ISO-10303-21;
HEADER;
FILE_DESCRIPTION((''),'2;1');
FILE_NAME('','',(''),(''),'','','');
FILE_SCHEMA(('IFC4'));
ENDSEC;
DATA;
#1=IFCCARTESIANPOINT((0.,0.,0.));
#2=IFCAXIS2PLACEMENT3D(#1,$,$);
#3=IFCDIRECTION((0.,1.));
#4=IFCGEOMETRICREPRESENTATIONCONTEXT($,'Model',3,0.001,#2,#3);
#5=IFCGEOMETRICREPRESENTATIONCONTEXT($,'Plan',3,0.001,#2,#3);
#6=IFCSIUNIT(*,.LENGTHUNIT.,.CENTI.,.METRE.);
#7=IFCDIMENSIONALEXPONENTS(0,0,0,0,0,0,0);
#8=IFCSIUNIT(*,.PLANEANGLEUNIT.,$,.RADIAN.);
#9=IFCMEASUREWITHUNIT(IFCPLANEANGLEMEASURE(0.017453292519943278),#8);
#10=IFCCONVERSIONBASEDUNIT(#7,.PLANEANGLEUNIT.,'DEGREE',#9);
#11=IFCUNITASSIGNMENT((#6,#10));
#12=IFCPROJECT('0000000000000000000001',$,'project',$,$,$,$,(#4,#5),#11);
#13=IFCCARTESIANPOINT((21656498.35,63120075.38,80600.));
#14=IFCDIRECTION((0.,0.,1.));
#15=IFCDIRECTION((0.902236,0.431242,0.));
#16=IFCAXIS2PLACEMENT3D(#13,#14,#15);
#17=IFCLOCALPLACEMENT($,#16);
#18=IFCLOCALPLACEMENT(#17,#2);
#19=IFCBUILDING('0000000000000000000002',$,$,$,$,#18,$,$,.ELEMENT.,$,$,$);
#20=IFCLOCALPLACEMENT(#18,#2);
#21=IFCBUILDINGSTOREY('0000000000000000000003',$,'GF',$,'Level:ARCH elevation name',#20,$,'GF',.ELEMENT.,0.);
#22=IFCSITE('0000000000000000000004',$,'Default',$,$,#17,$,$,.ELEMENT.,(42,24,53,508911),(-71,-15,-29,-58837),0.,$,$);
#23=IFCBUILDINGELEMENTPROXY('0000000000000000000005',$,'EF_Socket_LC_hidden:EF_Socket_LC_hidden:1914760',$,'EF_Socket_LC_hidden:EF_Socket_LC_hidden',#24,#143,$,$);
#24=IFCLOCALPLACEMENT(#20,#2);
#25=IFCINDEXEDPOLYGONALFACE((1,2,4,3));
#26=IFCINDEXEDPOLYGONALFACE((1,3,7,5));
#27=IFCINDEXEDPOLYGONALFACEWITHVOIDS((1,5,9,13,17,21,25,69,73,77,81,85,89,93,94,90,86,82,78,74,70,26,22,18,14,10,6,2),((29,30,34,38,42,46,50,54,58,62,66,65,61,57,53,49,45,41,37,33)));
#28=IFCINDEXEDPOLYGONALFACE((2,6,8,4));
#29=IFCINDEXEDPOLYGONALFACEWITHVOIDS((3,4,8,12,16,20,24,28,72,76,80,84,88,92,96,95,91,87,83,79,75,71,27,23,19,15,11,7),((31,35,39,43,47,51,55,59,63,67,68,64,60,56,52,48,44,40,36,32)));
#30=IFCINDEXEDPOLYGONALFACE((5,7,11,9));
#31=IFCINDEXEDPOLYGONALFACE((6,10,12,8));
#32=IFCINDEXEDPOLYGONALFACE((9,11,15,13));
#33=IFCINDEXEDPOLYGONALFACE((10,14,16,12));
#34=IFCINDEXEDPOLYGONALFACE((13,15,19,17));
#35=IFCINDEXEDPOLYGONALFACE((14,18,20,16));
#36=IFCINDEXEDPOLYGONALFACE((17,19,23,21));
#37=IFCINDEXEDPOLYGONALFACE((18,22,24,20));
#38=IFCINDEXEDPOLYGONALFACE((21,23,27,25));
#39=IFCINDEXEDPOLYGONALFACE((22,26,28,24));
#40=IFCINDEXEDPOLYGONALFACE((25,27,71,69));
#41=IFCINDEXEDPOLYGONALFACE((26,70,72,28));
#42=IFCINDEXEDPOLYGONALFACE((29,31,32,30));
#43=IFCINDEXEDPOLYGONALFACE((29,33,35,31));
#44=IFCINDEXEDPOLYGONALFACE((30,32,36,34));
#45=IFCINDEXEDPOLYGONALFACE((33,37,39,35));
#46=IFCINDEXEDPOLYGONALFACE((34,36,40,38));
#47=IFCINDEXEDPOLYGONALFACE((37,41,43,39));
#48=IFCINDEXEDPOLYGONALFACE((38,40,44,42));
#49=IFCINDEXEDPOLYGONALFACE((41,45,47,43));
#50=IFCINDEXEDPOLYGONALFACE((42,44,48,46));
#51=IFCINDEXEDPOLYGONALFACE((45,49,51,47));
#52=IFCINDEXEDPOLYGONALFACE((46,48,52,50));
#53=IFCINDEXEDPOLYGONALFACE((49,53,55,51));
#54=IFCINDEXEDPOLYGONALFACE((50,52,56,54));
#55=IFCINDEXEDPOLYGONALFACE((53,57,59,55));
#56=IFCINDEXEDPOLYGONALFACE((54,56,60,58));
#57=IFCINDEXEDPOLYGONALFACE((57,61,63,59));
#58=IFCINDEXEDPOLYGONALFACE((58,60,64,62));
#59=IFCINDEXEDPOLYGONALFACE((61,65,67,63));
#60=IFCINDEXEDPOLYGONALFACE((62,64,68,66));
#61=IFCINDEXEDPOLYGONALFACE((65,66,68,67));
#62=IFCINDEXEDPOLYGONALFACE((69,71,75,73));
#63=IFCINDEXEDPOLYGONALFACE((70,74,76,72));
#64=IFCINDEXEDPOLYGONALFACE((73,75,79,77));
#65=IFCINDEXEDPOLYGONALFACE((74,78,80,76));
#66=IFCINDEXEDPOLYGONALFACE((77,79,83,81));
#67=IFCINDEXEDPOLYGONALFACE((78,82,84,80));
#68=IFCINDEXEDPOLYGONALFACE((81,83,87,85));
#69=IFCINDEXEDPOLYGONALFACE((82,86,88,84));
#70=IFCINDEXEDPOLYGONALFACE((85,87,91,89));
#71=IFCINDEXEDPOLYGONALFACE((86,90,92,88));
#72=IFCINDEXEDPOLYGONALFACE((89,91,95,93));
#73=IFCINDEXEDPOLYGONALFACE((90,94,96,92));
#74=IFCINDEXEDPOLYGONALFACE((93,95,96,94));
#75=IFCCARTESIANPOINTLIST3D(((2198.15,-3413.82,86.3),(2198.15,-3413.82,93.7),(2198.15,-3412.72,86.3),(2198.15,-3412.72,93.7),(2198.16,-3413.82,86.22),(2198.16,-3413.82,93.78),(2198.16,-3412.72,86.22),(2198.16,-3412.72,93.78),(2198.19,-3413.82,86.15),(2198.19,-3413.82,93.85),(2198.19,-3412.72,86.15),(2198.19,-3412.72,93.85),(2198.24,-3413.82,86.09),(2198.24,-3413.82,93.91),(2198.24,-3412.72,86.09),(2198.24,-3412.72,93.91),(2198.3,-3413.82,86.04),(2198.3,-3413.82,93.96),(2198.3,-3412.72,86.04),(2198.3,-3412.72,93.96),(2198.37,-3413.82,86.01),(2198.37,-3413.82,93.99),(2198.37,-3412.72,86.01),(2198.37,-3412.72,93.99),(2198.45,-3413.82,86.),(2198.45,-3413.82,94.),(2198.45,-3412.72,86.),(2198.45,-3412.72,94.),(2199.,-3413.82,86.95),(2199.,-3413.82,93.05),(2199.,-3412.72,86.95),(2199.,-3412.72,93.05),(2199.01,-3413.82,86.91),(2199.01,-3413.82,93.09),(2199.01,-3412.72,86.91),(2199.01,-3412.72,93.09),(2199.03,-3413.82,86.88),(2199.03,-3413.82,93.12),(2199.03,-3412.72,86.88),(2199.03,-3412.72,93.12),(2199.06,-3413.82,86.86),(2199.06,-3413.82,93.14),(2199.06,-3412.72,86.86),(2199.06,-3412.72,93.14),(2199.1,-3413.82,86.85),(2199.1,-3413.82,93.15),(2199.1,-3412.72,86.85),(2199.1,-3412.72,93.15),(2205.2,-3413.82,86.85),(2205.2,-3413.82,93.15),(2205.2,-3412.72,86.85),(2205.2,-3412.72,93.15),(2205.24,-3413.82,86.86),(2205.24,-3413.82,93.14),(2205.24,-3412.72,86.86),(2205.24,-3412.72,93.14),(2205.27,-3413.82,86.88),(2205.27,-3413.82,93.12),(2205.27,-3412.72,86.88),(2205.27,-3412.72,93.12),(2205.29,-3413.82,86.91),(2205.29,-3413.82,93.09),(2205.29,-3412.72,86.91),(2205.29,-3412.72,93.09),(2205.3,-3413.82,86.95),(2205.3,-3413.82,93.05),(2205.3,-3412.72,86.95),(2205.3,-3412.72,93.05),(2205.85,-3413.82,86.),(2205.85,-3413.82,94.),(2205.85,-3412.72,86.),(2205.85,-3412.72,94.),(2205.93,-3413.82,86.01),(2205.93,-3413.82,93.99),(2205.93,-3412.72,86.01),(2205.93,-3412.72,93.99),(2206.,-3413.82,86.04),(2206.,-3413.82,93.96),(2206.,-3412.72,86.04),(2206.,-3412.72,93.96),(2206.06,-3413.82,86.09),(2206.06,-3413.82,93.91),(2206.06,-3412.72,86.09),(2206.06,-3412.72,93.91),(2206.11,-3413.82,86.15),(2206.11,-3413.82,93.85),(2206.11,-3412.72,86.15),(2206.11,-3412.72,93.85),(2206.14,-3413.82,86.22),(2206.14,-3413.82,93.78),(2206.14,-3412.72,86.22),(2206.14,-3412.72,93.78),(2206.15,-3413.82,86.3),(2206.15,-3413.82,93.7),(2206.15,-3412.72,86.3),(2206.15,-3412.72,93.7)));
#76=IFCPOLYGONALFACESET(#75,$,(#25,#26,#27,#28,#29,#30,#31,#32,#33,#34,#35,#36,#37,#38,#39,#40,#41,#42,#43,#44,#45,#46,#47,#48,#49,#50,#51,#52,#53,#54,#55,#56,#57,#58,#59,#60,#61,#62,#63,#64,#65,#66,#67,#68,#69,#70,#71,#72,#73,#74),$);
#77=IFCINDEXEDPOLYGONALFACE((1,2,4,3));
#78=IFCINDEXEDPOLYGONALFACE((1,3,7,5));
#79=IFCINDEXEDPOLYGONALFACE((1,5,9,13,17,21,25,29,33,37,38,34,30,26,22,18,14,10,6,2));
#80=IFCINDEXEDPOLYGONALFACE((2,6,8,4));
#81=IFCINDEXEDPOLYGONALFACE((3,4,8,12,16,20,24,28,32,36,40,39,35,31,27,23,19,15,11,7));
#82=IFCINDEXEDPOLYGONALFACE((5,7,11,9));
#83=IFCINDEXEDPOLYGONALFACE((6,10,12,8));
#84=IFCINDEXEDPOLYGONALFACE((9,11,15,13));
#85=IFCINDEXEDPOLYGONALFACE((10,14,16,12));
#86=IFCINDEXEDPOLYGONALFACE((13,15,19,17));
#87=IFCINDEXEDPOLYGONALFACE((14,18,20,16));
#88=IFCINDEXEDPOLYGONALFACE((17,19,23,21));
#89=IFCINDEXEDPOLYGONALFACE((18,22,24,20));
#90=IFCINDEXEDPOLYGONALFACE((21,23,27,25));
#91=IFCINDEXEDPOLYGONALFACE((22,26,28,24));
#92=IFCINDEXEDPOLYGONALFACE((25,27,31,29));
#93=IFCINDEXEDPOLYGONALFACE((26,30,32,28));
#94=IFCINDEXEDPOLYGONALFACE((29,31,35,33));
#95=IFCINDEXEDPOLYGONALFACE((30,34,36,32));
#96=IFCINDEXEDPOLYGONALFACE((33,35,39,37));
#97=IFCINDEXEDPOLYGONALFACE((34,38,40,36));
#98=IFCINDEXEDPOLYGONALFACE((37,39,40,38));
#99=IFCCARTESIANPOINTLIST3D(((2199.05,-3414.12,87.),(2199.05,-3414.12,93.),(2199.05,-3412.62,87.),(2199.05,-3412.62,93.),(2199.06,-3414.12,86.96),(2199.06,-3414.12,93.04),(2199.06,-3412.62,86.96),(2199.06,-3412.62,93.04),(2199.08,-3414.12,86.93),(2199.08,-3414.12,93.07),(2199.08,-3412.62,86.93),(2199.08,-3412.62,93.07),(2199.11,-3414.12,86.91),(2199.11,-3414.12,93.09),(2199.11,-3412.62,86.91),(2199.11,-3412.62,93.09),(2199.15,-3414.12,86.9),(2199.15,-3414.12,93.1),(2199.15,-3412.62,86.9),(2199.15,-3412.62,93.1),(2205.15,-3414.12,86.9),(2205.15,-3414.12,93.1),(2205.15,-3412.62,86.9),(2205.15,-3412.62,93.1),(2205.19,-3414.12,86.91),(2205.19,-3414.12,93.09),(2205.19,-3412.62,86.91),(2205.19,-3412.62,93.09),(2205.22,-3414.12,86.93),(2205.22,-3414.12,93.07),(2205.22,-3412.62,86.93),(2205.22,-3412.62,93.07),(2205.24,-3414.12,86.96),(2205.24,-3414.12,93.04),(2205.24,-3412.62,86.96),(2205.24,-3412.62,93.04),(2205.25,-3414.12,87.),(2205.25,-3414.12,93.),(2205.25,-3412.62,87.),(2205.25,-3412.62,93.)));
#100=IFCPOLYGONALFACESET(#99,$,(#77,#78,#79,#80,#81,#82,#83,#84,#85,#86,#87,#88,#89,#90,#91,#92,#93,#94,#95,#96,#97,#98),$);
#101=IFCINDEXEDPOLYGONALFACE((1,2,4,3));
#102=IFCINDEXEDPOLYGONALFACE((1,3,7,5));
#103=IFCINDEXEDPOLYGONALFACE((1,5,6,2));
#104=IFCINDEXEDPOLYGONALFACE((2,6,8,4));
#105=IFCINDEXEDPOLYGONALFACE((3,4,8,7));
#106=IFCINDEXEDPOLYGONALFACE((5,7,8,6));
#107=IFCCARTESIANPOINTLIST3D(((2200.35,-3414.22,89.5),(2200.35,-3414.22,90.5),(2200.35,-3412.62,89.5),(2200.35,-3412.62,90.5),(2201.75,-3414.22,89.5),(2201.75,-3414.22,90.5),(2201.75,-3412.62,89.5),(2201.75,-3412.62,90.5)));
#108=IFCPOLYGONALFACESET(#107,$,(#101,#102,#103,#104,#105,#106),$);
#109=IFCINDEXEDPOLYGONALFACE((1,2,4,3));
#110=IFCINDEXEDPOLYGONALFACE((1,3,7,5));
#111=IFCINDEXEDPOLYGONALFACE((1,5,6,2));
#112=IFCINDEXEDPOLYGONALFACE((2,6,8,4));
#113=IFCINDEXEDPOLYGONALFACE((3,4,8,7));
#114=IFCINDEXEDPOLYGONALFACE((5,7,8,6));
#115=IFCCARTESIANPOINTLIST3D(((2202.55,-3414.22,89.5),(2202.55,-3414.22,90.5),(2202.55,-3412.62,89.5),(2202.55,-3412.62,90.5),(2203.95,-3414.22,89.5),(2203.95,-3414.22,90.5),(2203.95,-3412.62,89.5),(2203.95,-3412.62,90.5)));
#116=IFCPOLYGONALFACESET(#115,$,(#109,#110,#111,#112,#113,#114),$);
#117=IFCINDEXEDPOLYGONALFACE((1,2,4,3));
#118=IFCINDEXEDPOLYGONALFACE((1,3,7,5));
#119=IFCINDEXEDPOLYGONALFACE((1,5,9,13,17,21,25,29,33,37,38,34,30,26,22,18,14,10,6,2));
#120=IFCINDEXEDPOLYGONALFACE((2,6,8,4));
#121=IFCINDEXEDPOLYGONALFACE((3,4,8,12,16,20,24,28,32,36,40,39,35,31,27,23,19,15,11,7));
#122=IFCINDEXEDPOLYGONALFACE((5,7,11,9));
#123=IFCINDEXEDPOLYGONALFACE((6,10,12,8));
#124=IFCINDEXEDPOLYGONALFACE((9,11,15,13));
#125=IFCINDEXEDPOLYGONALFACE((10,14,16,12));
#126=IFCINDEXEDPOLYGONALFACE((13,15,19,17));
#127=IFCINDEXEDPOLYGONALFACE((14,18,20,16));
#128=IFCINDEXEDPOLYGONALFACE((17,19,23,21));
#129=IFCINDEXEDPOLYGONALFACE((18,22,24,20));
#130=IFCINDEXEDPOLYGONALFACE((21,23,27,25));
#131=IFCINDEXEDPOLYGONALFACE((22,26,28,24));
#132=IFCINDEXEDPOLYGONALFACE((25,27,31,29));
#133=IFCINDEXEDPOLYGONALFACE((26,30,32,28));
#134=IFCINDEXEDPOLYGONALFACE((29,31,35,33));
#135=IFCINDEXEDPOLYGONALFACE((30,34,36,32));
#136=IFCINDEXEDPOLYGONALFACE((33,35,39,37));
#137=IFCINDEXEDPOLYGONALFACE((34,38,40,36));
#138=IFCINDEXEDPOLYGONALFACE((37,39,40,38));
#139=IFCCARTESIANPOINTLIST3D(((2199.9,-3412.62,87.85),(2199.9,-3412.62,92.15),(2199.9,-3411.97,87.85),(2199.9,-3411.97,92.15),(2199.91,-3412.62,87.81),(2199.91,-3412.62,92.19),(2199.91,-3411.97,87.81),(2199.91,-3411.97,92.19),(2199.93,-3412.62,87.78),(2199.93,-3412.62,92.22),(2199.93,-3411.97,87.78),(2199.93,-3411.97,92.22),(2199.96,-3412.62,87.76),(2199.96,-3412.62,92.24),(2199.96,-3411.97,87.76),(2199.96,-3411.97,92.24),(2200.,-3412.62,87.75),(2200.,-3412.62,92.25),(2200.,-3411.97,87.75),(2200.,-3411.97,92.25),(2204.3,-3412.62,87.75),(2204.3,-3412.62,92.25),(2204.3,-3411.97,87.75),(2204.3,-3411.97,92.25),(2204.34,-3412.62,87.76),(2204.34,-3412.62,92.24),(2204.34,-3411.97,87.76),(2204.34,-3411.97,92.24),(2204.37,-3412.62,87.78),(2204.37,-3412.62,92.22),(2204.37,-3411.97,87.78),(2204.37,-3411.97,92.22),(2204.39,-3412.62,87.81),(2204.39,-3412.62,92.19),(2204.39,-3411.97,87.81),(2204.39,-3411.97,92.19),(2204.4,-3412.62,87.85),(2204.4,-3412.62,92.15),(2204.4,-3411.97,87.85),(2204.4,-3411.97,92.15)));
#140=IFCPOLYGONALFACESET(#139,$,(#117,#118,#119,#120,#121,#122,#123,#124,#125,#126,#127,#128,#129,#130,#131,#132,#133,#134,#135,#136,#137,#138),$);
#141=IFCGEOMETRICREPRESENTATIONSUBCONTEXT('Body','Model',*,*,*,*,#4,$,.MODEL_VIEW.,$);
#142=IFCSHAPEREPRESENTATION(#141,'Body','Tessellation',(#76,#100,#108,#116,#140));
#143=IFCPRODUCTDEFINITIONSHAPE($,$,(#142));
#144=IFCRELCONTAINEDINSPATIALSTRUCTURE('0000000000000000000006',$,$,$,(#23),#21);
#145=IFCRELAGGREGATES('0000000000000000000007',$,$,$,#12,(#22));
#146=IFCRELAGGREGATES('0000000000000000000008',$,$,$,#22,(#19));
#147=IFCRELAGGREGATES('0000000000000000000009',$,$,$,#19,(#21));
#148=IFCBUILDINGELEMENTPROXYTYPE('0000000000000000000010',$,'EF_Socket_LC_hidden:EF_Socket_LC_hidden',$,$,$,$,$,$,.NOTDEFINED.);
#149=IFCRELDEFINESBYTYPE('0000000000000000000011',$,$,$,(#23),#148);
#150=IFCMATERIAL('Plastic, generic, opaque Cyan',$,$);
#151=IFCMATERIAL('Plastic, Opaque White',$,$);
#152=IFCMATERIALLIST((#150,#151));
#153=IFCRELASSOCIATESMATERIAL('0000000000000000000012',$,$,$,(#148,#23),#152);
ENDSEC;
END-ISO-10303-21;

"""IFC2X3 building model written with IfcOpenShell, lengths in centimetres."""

from ifc_helpers import new_model, entity, si_unit, converted_unit, direction, frame, frame_2d, origin, place, context, subcontext, project, spatial, polyline, circle_curve, parameter, trimmed, segment, composite_curve, rectangle, outline, extrude, source, transform, mapped, material, material_list, type_object, type_shapes, element, save


model = new_model("IFC2X3")

# Units and contexts
model_context = context("Model", 3, precision=0.001, world=origin(), true_north=direction((0.0, 1.0)))
plan_context = context("Plan", 3, precision=0.001, world=origin(), true_north=direction((0.0, 1.0)))
body_context = subcontext(model_context, "Body", "Model", "MODEL_VIEW")
ifc_project = project(units=[si_unit("LENGTHUNIT", "METRE", prefix="CENTI"), converted_unit("PLANEANGLEUNIT", "DEGREE", entity("IfcPlaneAngleMeasure", 0.017453292519943278), si_unit("PLANEANGLEUNIT", "RADIAN"), dimensions=[0, 0, 0, 0, 0, 0, 0])], contexts=[model_context, plan_context])

# Site, building, storey
site_placement = place(None, frame((21656498.35, 63120075.38, 80600.0), z_axis=(0.0, 0.0, 1.0), x_axis=(0.902236, 0.431242, 0.0)))
site = spatial("IfcSite", under=ifc_project, at=site_placement, Name="Default", CompositionType="ELEMENT", RefLatitude=(42, 24, 53, 508911), RefLongitude=(-71, -15, -29, -58837), RefElevation=0.0)
building_placement = place(site_placement, origin())
building = spatial("IfcBuilding", under=site, at=building_placement, CompositionType="ELEMENT")
storey_placement = place(building_placement, origin())
storey = spatial("IfcBuildingStorey", under=building, at=storey_placement, Name="GF", ObjectType="Level:ARCH elevation name", LongName="GF", CompositionType="ELEMENT", Elevation=0.0)

# Building element proxy
ifc_material_1 = material(Name="Plastic, generic, opaque Cyan")
ifc_material_2 = material(Name="Plastic, Opaque White")
ifc_material_list_1 = material_list([ifc_material_1, ifc_material_2])
building_element_proxy_type_1 = type_object("IfcBuildingElementProxyType", Name="EF_Socket_LC_hidden:EF_Socket_LC_hidden", PredefinedType="NOTDEFINED", material=ifc_material_list_1)
shared_shape_1 = source(origin(), body_context, "Body", "SweptSolid", [
    extrude(outline(composite_curve([segment(trimmed(circle_curve(frame_2d((3.7, -3.7), x_axis=(1.0, 0.0)), 0.3), [parameter(270.0)], [parameter(0.0)], True, "PARAMETER"), True, "CONTINUOUS"), segment(polyline([(4.0, -3.7), (4.0, 3.7)]), True, "CONTINUOUS"), segment(trimmed(circle_curve(frame_2d((3.7, 3.7), x_axis=(1.0, 0.0)), 0.3), [parameter(0.0)], [parameter(90.0)], True, "PARAMETER"), True, "CONTINUOUS"), segment(polyline([(3.7, 4.0), (-3.7, 4.0)]), True, "CONTINUOUS"), segment(trimmed(circle_curve(frame_2d((-3.7, 3.7), x_axis=(1.0, 0.0)), 0.3), [parameter(90.0)], [parameter(180.0)], True, "PARAMETER"), True, "CONTINUOUS"), segment(polyline([(-4.0, 3.7), (-4.0, -3.7)]), True, "CONTINUOUS"), segment(trimmed(circle_curve(frame_2d((-3.7, -3.7), x_axis=(1.0, 0.0)), 0.3), [parameter(180.0)], [parameter(270.0)], True, "PARAMETER"), True, "CONTINUOUS"), segment(polyline([(-3.7, -4.0), (3.7, -4.0)]), True, "CONTINUOUS")], self_intersect=False), holes=[composite_curve([segment(polyline([(-3.15, -3.05), (-3.15, 3.05)]), True, "CONTINUOUS"), segment(trimmed(circle_curve(frame_2d((-3.05, 3.05), x_axis=(1.0, 0.0)), 0.1), [parameter(90.0)], [parameter(180.0)], True, "PARAMETER"), False, "CONTINUOUS"), segment(polyline([(-3.05, 3.15), (3.05, 3.15)]), True, "CONTINUOUS"), segment(trimmed(circle_curve(frame_2d((3.05, 3.05), x_axis=(1.0, 0.0)), 0.1), [parameter(360.0)], [parameter(90.0)], True, "PARAMETER"), False, "CONTINUOUS"), segment(polyline([(3.15, 3.05), (3.15, -3.05)]), True, "CONTINUOUS"), segment(trimmed(circle_curve(frame_2d((3.05, -3.05), x_axis=(1.0, 0.0)), 0.1), [parameter(270.0)], [parameter(360.0)], True, "PARAMETER"), False, "CONTINUOUS"), segment(polyline([(3.05, -3.15), (-3.05, -3.15)]), True, "CONTINUOUS"), segment(trimmed(circle_curve(frame_2d((-3.05, -3.05), x_axis=(1.0, 0.0)), 0.1), [parameter(180.0)], [parameter(270.0)], True, "PARAMETER"), False, "CONTINUOUS")], self_intersect=False)]), frame((0.0, 0.0, 0.0), z_axis=(0.0, 1.0, 0.0), x_axis=(1.0, 0.0, 0.0)), (0.0, 0.0, 1.0), 1.1),
    extrude(outline(composite_curve([segment(trimmed(circle_curve(frame_2d((3.0, -3.0), x_axis=(1.0, 0.0)), 0.1), [parameter(270.0)], [parameter(0.0)], True, "PARAMETER"), True, "CONTINUOUS"), segment(polyline([(3.1, -3.0), (3.1, 3.0)]), True, "CONTINUOUS"), segment(trimmed(circle_curve(frame_2d((3.0, 3.0), x_axis=(1.0, 0.0)), 0.1), [parameter(0.0)], [parameter(90.0)], True, "PARAMETER"), True, "CONTINUOUS"), segment(polyline([(3.0, 3.1), (-3.0, 3.1)]), True, "CONTINUOUS"), segment(trimmed(circle_curve(frame_2d((-3.0, 3.0), x_axis=(1.0, 0.0)), 0.1), [parameter(90.0)], [parameter(180.0)], True, "PARAMETER"), True, "CONTINUOUS"), segment(polyline([(-3.1, 3.0), (-3.1, -3.0)]), True, "CONTINUOUS"), segment(trimmed(circle_curve(frame_2d((-3.0, -3.0), x_axis=(1.0, 0.0)), 0.1), [parameter(180.0)], [parameter(270.0)], True, "PARAMETER"), True, "CONTINUOUS"), segment(polyline([(-3.0, -3.1), (3.0, -3.1)]), True, "CONTINUOUS")], self_intersect=False)), frame((0.0, -0.1, 0.0), z_axis=(0.0, 1.0, 0.0), x_axis=(1.0, 0.0, 0.0)), (0.0, 0.0, 1.0), 1.5),
    extrude(rectangle(XDim=1.6, YDim=1.4, at=frame_2d((0.0, 0.0), x_axis=(1.0, 0.0))), frame((1.1, 0.7, -0.5), z_axis=(0.0, 0.0, 1.0), x_axis=(0.0, -1.0, 0.0)), (0.0, 0.0, 1.0), 1.0),
    extrude(rectangle(XDim=1.6, YDim=1.4, at=frame_2d((0.0, 0.0), x_axis=(1.0, 0.0))), frame((-1.1, 0.7, -0.5), z_axis=(0.0, 0.0, 1.0), x_axis=(0.0, -1.0, 0.0)), (0.0, 0.0, 1.0), 1.0),
    extrude(outline(composite_curve([segment(trimmed(circle_curve(frame_2d((2.15, -2.15), x_axis=(1.0, 0.0)), 0.1), [parameter(270.0)], [parameter(0.0)], True, "PARAMETER"), True, "CONTINUOUS"), segment(polyline([(2.25, -2.15), (2.25, 2.15)]), True, "CONTINUOUS"), segment(trimmed(circle_curve(frame_2d((2.15, 2.15), x_axis=(1.0, 0.0)), 0.1), [parameter(0.0)], [parameter(90.0)], True, "PARAMETER"), True, "CONTINUOUS"), segment(polyline([(2.15, 2.25), (-2.15, 2.25)]), True, "CONTINUOUS"), segment(trimmed(circle_curve(frame_2d((-2.15, 2.15), x_axis=(1.0, 0.0)), 0.1), [parameter(90.0)], [parameter(180.0)], True, "PARAMETER"), True, "CONTINUOUS"), segment(polyline([(-2.25, 2.15), (-2.25, -2.15)]), True, "CONTINUOUS"), segment(trimmed(circle_curve(frame_2d((-2.15, -2.15), x_axis=(1.0, 0.0)), 0.1), [parameter(180.0)], [parameter(270.0)], True, "PARAMETER"), True, "CONTINUOUS"), segment(polyline([(-2.15, -2.25), (2.15, -2.25)]), True, "CONTINUOUS")], self_intersect=False)), frame((0.0, -0.75, 0.0), z_axis=(0.0, 1.0, 0.0), x_axis=(1.0, 0.0, 0.0)), (0.0, 0.0, 1.0), 0.65),
])
type_shapes(building_element_proxy_type_1, [shared_shape_1])
for number, where, z_axis, x_axis, name in (
    (1, (2202.15, -3412.72, 90.0), (0.0, 0.0, 1.0), (-1.0, 0.0, 0.0), "EF_Socket_LC_hidden:EF_Socket_LC_hidden:1914760"),
):
    element("IfcBuildingElementProxy", number, at=place(storey_placement, frame(where, z_axis=z_axis, x_axis=x_axis)), inside=storey, type_object=building_element_proxy_type_1, material=ifc_material_list_1, Name=name, ObjectType="EF_Socket_LC_hidden:EF_Socket_LC_hidden", context=body_context, shape_type="MappedRepresentation", body=[
        mapped(shared_shape_1, transform((0.0, 0.0, 0.0), scale=1.0)),
    ])

save(model, "model.ifc")
